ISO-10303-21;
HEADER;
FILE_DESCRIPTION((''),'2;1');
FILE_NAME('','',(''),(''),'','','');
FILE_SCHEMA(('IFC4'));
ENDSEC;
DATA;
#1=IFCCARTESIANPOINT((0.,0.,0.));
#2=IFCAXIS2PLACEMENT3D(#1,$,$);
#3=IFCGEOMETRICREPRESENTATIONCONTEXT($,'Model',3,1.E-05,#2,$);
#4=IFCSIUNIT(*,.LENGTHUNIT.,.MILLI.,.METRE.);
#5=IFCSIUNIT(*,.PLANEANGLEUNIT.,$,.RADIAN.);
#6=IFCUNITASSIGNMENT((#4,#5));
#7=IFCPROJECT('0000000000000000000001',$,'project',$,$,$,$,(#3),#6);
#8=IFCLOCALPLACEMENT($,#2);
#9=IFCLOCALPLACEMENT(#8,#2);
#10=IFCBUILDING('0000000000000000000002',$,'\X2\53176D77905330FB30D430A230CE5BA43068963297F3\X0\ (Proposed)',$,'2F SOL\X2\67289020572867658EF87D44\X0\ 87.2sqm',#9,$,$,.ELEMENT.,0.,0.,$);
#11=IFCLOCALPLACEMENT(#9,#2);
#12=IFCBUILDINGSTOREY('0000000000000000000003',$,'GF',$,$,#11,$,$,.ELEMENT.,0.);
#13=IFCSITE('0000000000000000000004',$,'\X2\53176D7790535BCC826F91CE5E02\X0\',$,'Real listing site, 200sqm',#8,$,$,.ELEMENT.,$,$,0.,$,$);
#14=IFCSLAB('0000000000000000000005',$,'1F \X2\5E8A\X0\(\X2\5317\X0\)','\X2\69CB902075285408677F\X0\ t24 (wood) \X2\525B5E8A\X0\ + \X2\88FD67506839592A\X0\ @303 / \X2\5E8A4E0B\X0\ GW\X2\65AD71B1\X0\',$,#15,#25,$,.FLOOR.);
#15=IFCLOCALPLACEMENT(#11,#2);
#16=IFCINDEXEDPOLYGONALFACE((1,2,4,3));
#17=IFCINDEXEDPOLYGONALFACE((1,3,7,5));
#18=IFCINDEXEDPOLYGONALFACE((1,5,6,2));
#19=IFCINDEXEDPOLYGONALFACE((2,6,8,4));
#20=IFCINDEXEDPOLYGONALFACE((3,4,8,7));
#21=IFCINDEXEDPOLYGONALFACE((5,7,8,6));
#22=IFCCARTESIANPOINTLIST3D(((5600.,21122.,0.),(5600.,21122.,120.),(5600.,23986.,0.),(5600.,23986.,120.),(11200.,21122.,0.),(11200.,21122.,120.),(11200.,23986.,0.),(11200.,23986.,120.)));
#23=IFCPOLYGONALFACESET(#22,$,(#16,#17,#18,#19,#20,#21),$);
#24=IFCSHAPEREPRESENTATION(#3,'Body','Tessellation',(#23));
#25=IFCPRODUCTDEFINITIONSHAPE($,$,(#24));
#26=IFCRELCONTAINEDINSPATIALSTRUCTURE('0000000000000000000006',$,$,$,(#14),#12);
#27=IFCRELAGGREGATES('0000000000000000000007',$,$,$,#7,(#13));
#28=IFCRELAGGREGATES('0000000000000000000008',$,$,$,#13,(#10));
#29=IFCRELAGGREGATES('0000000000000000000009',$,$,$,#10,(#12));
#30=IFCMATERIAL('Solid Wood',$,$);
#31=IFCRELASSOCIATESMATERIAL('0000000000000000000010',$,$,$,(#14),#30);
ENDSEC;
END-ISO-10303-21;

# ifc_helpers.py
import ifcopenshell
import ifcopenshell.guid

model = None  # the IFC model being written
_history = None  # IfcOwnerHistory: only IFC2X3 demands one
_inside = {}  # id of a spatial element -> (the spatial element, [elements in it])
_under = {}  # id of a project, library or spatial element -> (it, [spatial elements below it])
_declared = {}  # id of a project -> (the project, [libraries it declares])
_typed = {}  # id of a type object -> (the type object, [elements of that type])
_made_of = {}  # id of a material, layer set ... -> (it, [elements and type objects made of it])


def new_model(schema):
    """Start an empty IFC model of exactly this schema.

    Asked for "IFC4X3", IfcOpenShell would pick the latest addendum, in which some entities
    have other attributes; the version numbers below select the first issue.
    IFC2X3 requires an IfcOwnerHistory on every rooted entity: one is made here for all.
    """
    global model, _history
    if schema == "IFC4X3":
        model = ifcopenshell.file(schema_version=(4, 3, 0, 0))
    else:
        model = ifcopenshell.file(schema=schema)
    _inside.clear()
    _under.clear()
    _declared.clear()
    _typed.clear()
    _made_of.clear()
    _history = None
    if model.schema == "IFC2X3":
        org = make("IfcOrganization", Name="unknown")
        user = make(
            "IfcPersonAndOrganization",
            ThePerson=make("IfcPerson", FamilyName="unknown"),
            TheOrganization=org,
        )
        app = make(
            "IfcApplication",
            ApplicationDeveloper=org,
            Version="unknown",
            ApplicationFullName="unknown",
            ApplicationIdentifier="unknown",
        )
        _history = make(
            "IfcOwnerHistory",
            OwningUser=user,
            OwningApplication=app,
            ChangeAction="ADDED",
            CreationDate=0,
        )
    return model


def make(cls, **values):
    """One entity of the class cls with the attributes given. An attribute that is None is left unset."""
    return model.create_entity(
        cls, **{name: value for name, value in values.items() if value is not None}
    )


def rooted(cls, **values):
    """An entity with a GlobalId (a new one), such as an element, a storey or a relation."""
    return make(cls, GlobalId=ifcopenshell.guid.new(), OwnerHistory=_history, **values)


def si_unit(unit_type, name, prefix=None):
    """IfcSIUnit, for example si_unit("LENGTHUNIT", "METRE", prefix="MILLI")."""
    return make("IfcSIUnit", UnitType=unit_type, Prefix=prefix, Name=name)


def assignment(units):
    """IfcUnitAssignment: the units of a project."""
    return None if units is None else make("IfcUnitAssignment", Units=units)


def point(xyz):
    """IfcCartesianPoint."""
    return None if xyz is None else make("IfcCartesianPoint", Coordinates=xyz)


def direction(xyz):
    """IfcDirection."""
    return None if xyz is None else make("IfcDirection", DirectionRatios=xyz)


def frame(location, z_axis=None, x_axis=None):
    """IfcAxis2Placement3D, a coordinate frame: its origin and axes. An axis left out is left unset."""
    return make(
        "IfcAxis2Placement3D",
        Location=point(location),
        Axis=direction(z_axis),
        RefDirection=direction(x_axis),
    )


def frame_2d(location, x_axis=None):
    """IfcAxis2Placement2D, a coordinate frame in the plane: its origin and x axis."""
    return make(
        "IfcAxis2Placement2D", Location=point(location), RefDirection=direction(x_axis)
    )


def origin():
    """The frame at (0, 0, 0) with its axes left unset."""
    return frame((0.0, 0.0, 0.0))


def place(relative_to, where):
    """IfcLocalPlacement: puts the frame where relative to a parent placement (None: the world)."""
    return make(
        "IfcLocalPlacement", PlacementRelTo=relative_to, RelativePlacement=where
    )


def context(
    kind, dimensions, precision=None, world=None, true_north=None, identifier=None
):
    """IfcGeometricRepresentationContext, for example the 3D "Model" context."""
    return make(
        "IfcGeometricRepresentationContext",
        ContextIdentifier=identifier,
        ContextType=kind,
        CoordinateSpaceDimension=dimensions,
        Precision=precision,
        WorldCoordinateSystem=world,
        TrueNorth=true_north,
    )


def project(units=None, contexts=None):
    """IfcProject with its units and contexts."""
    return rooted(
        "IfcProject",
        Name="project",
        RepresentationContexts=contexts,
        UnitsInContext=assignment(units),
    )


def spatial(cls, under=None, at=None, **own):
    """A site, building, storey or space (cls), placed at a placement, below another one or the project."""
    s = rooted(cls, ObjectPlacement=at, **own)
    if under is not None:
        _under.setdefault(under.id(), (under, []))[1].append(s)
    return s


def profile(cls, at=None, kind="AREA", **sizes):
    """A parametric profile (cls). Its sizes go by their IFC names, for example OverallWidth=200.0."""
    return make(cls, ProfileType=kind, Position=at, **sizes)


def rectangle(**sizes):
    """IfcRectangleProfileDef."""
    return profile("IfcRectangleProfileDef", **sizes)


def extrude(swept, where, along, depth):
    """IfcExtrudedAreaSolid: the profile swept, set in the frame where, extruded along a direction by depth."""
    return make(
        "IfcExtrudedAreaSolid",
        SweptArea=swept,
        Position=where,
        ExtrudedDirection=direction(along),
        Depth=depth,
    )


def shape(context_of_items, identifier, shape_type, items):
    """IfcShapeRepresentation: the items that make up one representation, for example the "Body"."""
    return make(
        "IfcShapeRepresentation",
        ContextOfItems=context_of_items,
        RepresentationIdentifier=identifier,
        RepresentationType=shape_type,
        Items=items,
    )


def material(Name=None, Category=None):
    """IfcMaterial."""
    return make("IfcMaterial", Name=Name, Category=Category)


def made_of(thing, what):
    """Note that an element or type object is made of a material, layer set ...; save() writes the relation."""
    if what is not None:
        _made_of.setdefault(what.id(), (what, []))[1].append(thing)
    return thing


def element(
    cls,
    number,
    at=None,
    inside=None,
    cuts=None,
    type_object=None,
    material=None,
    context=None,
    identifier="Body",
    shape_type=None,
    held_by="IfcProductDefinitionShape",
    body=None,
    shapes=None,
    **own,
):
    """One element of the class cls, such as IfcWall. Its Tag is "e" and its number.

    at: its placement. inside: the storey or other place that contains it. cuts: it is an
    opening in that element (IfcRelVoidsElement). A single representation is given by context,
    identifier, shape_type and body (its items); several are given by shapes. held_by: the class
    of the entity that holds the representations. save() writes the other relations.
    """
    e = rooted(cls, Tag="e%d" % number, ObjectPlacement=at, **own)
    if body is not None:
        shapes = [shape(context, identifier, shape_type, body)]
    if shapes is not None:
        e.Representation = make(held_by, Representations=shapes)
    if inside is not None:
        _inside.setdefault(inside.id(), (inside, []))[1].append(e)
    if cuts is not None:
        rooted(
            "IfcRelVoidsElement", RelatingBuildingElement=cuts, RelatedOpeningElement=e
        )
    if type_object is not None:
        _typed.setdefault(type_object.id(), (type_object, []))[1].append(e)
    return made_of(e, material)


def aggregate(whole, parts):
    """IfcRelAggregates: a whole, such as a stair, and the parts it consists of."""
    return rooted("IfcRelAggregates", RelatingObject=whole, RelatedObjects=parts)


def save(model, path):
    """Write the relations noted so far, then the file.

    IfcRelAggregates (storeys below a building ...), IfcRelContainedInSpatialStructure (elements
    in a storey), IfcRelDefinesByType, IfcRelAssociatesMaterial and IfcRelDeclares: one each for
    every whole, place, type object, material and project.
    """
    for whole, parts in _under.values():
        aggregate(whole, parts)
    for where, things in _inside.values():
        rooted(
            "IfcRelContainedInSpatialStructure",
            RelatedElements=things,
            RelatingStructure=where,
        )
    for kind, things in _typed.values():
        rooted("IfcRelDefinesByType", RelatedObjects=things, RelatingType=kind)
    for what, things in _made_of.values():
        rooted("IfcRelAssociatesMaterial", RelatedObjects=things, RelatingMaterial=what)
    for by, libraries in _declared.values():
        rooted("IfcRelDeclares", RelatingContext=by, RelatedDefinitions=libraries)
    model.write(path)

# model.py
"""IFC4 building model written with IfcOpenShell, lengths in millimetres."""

from ifc_helpers import new_model, si_unit, frame, frame_2d, origin, place, context, project, spatial, rectangle, extrude, material, element, save


model = new_model("IFC4")

# Units and contexts
model_context = context("Model", 3, precision=1e-05, world=origin())
ifc_project = project(units=[si_unit("LENGTHUNIT", "METRE", prefix="MILLI"), si_unit("PLANEANGLEUNIT", "RADIAN")], contexts=[model_context])

# Site, building, storey
site_placement = place(None, origin())
site = spatial("IfcSite", under=ifc_project, at=site_placement, Name="北海道富良野市", ObjectType="Real listing site, 200sqm", CompositionType="ELEMENT", RefElevation=0.0)
building_placement = place(site_placement, origin())
building = spatial("IfcBuilding", under=site, at=building_placement, Name="北海道・ピアノ室と防音 (Proposed)", ObjectType="2F SOL木造在来軸組 87.2sqm", CompositionType="ELEMENT", ElevationOfRefHeight=0.0, ElevationOfTerrain=0.0)
storey_placement = place(building_placement, origin())
storey = spatial("IfcBuildingStorey", under=building, at=storey_placement, Name="GF", CompositionType="ELEMENT", Elevation=0.0)

# Shared definitions
ifc_material_1 = material(Name="Solid Wood")

# Slab
slab_1_placement = place(storey_placement, frame((2800.0, 10561.0, 0.0)))
element("IfcSlab", 1, at=slab_1_placement, inside=storey, material=ifc_material_1, Name="1F 床(北)", Description="構造用合板 t24 (wood) 剛床 + 製材根太 @303 / 床下 GW断熱", PredefinedType="FLOOR", context=model_context, shape_type="SweptSolid", body=[
    extrude(rectangle(XDim=5600.0, YDim=2864.0, at=frame_2d((2800.0, 1432.0))), frame((2800.0, 10561.0, 0.0)), (0.0, 0.0, 1.0), 120.0),
])

save(model, "model.ifc")
